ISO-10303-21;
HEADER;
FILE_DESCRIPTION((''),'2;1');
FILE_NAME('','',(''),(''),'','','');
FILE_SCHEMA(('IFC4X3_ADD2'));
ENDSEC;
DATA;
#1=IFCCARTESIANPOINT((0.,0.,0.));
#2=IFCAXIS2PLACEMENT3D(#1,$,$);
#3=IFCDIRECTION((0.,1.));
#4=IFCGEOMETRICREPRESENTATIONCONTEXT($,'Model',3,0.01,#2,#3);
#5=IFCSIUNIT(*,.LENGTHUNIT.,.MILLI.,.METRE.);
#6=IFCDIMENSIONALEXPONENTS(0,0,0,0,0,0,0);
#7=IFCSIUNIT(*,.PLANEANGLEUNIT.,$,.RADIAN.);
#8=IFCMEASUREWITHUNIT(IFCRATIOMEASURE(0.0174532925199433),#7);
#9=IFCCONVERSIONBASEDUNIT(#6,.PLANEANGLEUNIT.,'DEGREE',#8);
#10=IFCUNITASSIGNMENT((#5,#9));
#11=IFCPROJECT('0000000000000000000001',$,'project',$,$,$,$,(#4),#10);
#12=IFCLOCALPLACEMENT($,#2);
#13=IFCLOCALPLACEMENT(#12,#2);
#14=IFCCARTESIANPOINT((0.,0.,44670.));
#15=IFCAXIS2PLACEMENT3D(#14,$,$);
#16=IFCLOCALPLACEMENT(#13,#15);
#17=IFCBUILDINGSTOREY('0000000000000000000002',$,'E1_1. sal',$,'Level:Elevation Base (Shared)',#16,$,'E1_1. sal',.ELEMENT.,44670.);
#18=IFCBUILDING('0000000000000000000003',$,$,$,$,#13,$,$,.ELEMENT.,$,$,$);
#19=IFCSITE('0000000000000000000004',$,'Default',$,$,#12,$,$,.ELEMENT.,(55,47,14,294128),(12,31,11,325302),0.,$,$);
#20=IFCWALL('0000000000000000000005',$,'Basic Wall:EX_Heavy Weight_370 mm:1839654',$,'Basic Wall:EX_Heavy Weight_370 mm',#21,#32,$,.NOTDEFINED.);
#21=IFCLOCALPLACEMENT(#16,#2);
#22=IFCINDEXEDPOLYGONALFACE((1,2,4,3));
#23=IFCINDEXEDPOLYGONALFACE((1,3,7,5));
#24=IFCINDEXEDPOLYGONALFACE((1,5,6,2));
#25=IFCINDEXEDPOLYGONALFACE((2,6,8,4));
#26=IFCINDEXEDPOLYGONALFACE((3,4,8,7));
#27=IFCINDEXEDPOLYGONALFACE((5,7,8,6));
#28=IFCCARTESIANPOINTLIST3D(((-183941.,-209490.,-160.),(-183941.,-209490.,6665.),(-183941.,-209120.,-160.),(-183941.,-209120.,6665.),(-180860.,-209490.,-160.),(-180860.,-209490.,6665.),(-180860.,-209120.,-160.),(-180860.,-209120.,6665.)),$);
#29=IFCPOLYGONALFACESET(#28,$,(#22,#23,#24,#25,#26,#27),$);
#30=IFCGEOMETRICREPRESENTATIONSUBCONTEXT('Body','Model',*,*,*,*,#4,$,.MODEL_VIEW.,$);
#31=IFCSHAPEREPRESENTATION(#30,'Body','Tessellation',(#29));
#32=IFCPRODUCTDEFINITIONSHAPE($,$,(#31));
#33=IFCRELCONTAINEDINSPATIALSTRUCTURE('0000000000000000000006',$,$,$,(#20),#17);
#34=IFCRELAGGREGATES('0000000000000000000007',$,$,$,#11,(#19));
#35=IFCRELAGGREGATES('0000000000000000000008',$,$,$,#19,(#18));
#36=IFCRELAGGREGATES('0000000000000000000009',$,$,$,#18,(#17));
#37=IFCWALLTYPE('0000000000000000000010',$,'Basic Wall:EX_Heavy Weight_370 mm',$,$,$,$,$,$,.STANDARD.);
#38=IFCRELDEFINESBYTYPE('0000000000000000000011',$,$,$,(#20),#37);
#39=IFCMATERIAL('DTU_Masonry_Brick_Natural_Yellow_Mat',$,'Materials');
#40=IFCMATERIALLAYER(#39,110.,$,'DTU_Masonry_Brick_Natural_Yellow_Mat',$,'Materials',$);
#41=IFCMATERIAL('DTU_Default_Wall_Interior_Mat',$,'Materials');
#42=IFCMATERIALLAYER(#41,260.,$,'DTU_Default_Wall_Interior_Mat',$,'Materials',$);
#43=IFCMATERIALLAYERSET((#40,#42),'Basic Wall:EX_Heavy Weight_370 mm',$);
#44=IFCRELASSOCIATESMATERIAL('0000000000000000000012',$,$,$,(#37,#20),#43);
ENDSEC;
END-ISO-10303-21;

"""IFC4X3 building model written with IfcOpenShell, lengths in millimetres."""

from ifc_helpers import new_model, entity, si_unit, converted_unit, direction, frame, frame_2d, origin, place, context, subcontext, project, spatial, rectangle, extrude, material, layer, layer_set, type_object, element, save


model = new_model("IFC4X3")

# Units and contexts
model_context = context("Model", 3, precision=0.01, world=origin(), true_north=direction((0.0, 1.0)))
body_context = subcontext(model_context, "Body", "Model", "MODEL_VIEW")
ifc_project = project(units=[si_unit("LENGTHUNIT", "METRE", prefix="MILLI"), converted_unit("PLANEANGLEUNIT", "DEGREE", entity("IfcRatioMeasure", 0.0174532925199433), si_unit("PLANEANGLEUNIT", "RADIAN"), dimensions=[0, 0, 0, 0, 0, 0, 0])], contexts=[model_context])

# Site, building, storey
site_placement = place(None, origin())
site = spatial("IfcSite", under=ifc_project, at=site_placement, Name="Default", CompositionType="ELEMENT", RefLatitude=(55, 47, 14, 294128), RefLongitude=(12, 31, 11, 325302), RefElevation=0.0)
building_placement = place(site_placement, origin())
building = spatial("IfcBuilding", under=site, at=building_placement, CompositionType="ELEMENT")
storey_placement = place(building_placement, frame((0.0, 0.0, 44670.0)))
storey = spatial("IfcBuildingStorey", under=building, at=storey_placement, Name="E1_1. sal", ObjectType="Level:Elevation Base (Shared)", LongName="E1_1. sal", CompositionType="ELEMENT", Elevation=44670.0)

# Shared definitions
ifc_material_1 = material(Name="DTU_Default_Wall_Interior_Mat", Category="Materials")

# Shared definitions
ifc_material_2 = material(Name="DTU_Masonry_Brick_Natural_Yellow_Mat", Category="Materials")

# Wall
ifc_layer_1 = layer(ifc_material_2, 110.0, Name="DTU_Masonry_Brick_Natural_Yellow_Mat", Category="Materials")
ifc_layer_2 = layer(ifc_material_1, 260.0, Name="DTU_Default_Wall_Interior_Mat", Category="Materials")
ifc_layer_set_1 = layer_set([ifc_layer_1, ifc_layer_2], Name="Basic Wall:EX_Heavy Weight_370 mm")
wall_type_1 = type_object("IfcWallType", Name="Basic Wall:EX_Heavy Weight_370 mm", PredefinedType="STANDARD", material=ifc_layer_set_1)
wall_1_placement = place(storey_placement, frame((-183941.0, -209305.0, -160.0)))
element("IfcWall", 1, at=wall_1_placement, inside=storey, type_object=wall_type_1, material=ifc_layer_set_1, Name="Basic Wall:EX_Heavy Weight_370 mm:1839654", ObjectType="Basic Wall:EX_Heavy Weight_370 mm", PredefinedType="NOTDEFINED", context=body_context, shape_type="SweptSolid", body=[
    extrude(rectangle(XDim=3081.0, YDim=370.0, at=frame_2d((1540.5, 0.0), x_axis=(-1.0, 0.0))), origin(), (0.0, 0.0, 1.0), 6825.0),
])

save(model, "model.ifc")
